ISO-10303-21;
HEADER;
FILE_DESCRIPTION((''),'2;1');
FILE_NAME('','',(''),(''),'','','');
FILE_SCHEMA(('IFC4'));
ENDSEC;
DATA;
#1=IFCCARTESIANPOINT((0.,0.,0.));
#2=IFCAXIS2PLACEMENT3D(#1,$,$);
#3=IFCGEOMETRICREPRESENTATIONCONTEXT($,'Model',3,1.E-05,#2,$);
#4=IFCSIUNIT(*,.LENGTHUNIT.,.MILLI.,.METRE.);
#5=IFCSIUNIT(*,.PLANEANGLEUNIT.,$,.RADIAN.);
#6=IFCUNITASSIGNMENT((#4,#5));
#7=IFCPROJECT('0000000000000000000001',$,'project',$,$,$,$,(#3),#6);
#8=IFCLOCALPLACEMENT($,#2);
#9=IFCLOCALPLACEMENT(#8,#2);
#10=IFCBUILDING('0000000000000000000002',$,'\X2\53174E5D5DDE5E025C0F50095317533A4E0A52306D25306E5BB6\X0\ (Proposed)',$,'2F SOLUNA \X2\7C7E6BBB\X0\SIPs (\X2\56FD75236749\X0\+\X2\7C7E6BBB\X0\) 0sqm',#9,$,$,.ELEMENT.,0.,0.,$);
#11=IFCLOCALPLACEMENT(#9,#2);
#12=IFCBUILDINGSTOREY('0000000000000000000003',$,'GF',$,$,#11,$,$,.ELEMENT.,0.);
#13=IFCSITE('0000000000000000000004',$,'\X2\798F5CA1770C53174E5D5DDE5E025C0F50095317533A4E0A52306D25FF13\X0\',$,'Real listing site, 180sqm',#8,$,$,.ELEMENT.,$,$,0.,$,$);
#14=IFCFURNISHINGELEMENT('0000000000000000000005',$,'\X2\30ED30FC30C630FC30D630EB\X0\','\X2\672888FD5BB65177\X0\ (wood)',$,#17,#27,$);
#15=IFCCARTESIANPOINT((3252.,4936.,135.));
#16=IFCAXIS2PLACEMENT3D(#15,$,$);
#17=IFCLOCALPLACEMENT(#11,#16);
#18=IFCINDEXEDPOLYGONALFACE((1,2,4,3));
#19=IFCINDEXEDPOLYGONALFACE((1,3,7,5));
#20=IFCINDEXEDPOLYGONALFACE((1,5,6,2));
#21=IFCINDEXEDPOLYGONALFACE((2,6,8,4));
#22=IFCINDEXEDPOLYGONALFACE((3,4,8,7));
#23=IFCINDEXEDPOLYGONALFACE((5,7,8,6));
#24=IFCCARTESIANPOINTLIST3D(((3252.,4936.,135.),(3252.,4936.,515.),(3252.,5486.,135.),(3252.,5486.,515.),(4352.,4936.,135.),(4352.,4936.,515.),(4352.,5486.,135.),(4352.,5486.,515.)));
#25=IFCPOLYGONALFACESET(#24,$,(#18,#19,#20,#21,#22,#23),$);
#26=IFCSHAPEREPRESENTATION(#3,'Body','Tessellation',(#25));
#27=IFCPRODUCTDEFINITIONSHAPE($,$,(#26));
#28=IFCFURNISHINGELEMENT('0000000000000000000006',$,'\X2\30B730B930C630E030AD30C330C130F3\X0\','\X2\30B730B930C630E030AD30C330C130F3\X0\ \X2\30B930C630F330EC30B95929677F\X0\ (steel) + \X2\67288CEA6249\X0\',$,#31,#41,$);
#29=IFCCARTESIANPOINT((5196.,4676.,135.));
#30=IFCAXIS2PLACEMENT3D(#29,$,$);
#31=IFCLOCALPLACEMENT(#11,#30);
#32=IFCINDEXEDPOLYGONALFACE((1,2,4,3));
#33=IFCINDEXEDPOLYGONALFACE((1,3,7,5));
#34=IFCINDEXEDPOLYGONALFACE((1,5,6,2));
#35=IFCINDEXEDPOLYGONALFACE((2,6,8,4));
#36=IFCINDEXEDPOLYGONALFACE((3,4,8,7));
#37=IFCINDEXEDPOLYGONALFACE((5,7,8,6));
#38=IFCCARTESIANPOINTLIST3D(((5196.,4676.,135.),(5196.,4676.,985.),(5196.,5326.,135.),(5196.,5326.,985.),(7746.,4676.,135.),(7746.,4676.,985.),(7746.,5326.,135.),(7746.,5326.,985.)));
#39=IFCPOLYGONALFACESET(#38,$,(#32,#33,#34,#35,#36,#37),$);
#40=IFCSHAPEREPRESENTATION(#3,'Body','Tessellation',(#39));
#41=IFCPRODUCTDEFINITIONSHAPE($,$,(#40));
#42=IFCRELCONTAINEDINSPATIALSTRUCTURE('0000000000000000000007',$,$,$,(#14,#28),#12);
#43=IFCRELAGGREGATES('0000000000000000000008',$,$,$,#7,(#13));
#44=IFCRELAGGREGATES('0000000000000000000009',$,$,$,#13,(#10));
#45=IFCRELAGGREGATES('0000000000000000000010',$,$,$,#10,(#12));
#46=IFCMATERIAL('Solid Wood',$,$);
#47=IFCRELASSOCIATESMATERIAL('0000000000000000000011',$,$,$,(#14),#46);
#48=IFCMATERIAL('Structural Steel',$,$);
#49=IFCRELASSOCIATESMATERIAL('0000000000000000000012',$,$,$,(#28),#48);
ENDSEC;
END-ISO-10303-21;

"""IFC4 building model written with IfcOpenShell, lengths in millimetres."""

from ifc_helpers import new_model, si_unit, frame, frame_2d, origin, place, context, project, spatial, rectangle, extrude, material, element, save


model = new_model("IFC4")

# Units and contexts
model_context = context("Model", 3, precision=1e-05, world=origin())
ifc_project = project(units=[si_unit("LENGTHUNIT", "METRE", prefix="MILLI"), si_unit("PLANEANGLEUNIT", "RADIAN")], contexts=[model_context])

# Site, building, storey
site_placement = place(None, origin())
site = spatial("IfcSite", under=ifc_project, at=site_placement, Name="福岡県北九州市小倉北区上到津３", ObjectType="Real listing site, 180sqm", CompositionType="ELEMENT", RefElevation=0.0)
building_placement = place(site_placement, origin())
building = spatial("IfcBuilding", under=site, at=building_placement, Name="北九州市小倉北区上到津の家 (Proposed)", ObjectType="2F SOLUNA 籾殻SIPs (国産杉+籾殻) 0sqm", CompositionType="ELEMENT", ElevationOfRefHeight=0.0, ElevationOfTerrain=0.0)
storey_placement = place(building_placement, origin())
storey = spatial("IfcBuildingStorey", under=building, at=storey_placement, Name="GF", CompositionType="ELEMENT", Elevation=0.0)

# Shared definitions
ifc_material_1 = material(Name="Solid Wood")

# Furnishing elements
furnishing_1_placement = place(storey_placement, frame((3252.0, 4936.0, 135.0)))
element("IfcFurnishingElement", 1, at=furnishing_1_placement, inside=storey, material=ifc_material_1, Name="ローテーブル", Description="木製家具 (wood)", context=model_context, shape_type="SweptSolid", body=[
    extrude(rectangle(XDim=1100.0, YDim=550.0, at=frame_2d((550.0, 275.0))), frame((3252.0, 4936.0, 135.0)), (0.0, 0.0, 1.0), 380.0),
])
ifc_material_2 = material(Name="Structural Steel")
furnishing_2_placement = place(storey_placement, frame((5196.0, 4676.0, 135.0)))
element("IfcFurnishingElement", 2, at=furnishing_2_placement, inside=storey, material=ifc_material_2, Name="システムキッチン", Description="システムキッチン ステンレス天板 (steel) + 木質扉", context=model_context, shape_type="SweptSolid", body=[
    extrude(rectangle(XDim=2550.0, YDim=650.0, at=frame_2d((1275.0, 325.0))), frame((5196.0, 4676.0, 135.0)), (0.0, 0.0, 1.0), 850.0),
])

save(model, "model.ifc")
